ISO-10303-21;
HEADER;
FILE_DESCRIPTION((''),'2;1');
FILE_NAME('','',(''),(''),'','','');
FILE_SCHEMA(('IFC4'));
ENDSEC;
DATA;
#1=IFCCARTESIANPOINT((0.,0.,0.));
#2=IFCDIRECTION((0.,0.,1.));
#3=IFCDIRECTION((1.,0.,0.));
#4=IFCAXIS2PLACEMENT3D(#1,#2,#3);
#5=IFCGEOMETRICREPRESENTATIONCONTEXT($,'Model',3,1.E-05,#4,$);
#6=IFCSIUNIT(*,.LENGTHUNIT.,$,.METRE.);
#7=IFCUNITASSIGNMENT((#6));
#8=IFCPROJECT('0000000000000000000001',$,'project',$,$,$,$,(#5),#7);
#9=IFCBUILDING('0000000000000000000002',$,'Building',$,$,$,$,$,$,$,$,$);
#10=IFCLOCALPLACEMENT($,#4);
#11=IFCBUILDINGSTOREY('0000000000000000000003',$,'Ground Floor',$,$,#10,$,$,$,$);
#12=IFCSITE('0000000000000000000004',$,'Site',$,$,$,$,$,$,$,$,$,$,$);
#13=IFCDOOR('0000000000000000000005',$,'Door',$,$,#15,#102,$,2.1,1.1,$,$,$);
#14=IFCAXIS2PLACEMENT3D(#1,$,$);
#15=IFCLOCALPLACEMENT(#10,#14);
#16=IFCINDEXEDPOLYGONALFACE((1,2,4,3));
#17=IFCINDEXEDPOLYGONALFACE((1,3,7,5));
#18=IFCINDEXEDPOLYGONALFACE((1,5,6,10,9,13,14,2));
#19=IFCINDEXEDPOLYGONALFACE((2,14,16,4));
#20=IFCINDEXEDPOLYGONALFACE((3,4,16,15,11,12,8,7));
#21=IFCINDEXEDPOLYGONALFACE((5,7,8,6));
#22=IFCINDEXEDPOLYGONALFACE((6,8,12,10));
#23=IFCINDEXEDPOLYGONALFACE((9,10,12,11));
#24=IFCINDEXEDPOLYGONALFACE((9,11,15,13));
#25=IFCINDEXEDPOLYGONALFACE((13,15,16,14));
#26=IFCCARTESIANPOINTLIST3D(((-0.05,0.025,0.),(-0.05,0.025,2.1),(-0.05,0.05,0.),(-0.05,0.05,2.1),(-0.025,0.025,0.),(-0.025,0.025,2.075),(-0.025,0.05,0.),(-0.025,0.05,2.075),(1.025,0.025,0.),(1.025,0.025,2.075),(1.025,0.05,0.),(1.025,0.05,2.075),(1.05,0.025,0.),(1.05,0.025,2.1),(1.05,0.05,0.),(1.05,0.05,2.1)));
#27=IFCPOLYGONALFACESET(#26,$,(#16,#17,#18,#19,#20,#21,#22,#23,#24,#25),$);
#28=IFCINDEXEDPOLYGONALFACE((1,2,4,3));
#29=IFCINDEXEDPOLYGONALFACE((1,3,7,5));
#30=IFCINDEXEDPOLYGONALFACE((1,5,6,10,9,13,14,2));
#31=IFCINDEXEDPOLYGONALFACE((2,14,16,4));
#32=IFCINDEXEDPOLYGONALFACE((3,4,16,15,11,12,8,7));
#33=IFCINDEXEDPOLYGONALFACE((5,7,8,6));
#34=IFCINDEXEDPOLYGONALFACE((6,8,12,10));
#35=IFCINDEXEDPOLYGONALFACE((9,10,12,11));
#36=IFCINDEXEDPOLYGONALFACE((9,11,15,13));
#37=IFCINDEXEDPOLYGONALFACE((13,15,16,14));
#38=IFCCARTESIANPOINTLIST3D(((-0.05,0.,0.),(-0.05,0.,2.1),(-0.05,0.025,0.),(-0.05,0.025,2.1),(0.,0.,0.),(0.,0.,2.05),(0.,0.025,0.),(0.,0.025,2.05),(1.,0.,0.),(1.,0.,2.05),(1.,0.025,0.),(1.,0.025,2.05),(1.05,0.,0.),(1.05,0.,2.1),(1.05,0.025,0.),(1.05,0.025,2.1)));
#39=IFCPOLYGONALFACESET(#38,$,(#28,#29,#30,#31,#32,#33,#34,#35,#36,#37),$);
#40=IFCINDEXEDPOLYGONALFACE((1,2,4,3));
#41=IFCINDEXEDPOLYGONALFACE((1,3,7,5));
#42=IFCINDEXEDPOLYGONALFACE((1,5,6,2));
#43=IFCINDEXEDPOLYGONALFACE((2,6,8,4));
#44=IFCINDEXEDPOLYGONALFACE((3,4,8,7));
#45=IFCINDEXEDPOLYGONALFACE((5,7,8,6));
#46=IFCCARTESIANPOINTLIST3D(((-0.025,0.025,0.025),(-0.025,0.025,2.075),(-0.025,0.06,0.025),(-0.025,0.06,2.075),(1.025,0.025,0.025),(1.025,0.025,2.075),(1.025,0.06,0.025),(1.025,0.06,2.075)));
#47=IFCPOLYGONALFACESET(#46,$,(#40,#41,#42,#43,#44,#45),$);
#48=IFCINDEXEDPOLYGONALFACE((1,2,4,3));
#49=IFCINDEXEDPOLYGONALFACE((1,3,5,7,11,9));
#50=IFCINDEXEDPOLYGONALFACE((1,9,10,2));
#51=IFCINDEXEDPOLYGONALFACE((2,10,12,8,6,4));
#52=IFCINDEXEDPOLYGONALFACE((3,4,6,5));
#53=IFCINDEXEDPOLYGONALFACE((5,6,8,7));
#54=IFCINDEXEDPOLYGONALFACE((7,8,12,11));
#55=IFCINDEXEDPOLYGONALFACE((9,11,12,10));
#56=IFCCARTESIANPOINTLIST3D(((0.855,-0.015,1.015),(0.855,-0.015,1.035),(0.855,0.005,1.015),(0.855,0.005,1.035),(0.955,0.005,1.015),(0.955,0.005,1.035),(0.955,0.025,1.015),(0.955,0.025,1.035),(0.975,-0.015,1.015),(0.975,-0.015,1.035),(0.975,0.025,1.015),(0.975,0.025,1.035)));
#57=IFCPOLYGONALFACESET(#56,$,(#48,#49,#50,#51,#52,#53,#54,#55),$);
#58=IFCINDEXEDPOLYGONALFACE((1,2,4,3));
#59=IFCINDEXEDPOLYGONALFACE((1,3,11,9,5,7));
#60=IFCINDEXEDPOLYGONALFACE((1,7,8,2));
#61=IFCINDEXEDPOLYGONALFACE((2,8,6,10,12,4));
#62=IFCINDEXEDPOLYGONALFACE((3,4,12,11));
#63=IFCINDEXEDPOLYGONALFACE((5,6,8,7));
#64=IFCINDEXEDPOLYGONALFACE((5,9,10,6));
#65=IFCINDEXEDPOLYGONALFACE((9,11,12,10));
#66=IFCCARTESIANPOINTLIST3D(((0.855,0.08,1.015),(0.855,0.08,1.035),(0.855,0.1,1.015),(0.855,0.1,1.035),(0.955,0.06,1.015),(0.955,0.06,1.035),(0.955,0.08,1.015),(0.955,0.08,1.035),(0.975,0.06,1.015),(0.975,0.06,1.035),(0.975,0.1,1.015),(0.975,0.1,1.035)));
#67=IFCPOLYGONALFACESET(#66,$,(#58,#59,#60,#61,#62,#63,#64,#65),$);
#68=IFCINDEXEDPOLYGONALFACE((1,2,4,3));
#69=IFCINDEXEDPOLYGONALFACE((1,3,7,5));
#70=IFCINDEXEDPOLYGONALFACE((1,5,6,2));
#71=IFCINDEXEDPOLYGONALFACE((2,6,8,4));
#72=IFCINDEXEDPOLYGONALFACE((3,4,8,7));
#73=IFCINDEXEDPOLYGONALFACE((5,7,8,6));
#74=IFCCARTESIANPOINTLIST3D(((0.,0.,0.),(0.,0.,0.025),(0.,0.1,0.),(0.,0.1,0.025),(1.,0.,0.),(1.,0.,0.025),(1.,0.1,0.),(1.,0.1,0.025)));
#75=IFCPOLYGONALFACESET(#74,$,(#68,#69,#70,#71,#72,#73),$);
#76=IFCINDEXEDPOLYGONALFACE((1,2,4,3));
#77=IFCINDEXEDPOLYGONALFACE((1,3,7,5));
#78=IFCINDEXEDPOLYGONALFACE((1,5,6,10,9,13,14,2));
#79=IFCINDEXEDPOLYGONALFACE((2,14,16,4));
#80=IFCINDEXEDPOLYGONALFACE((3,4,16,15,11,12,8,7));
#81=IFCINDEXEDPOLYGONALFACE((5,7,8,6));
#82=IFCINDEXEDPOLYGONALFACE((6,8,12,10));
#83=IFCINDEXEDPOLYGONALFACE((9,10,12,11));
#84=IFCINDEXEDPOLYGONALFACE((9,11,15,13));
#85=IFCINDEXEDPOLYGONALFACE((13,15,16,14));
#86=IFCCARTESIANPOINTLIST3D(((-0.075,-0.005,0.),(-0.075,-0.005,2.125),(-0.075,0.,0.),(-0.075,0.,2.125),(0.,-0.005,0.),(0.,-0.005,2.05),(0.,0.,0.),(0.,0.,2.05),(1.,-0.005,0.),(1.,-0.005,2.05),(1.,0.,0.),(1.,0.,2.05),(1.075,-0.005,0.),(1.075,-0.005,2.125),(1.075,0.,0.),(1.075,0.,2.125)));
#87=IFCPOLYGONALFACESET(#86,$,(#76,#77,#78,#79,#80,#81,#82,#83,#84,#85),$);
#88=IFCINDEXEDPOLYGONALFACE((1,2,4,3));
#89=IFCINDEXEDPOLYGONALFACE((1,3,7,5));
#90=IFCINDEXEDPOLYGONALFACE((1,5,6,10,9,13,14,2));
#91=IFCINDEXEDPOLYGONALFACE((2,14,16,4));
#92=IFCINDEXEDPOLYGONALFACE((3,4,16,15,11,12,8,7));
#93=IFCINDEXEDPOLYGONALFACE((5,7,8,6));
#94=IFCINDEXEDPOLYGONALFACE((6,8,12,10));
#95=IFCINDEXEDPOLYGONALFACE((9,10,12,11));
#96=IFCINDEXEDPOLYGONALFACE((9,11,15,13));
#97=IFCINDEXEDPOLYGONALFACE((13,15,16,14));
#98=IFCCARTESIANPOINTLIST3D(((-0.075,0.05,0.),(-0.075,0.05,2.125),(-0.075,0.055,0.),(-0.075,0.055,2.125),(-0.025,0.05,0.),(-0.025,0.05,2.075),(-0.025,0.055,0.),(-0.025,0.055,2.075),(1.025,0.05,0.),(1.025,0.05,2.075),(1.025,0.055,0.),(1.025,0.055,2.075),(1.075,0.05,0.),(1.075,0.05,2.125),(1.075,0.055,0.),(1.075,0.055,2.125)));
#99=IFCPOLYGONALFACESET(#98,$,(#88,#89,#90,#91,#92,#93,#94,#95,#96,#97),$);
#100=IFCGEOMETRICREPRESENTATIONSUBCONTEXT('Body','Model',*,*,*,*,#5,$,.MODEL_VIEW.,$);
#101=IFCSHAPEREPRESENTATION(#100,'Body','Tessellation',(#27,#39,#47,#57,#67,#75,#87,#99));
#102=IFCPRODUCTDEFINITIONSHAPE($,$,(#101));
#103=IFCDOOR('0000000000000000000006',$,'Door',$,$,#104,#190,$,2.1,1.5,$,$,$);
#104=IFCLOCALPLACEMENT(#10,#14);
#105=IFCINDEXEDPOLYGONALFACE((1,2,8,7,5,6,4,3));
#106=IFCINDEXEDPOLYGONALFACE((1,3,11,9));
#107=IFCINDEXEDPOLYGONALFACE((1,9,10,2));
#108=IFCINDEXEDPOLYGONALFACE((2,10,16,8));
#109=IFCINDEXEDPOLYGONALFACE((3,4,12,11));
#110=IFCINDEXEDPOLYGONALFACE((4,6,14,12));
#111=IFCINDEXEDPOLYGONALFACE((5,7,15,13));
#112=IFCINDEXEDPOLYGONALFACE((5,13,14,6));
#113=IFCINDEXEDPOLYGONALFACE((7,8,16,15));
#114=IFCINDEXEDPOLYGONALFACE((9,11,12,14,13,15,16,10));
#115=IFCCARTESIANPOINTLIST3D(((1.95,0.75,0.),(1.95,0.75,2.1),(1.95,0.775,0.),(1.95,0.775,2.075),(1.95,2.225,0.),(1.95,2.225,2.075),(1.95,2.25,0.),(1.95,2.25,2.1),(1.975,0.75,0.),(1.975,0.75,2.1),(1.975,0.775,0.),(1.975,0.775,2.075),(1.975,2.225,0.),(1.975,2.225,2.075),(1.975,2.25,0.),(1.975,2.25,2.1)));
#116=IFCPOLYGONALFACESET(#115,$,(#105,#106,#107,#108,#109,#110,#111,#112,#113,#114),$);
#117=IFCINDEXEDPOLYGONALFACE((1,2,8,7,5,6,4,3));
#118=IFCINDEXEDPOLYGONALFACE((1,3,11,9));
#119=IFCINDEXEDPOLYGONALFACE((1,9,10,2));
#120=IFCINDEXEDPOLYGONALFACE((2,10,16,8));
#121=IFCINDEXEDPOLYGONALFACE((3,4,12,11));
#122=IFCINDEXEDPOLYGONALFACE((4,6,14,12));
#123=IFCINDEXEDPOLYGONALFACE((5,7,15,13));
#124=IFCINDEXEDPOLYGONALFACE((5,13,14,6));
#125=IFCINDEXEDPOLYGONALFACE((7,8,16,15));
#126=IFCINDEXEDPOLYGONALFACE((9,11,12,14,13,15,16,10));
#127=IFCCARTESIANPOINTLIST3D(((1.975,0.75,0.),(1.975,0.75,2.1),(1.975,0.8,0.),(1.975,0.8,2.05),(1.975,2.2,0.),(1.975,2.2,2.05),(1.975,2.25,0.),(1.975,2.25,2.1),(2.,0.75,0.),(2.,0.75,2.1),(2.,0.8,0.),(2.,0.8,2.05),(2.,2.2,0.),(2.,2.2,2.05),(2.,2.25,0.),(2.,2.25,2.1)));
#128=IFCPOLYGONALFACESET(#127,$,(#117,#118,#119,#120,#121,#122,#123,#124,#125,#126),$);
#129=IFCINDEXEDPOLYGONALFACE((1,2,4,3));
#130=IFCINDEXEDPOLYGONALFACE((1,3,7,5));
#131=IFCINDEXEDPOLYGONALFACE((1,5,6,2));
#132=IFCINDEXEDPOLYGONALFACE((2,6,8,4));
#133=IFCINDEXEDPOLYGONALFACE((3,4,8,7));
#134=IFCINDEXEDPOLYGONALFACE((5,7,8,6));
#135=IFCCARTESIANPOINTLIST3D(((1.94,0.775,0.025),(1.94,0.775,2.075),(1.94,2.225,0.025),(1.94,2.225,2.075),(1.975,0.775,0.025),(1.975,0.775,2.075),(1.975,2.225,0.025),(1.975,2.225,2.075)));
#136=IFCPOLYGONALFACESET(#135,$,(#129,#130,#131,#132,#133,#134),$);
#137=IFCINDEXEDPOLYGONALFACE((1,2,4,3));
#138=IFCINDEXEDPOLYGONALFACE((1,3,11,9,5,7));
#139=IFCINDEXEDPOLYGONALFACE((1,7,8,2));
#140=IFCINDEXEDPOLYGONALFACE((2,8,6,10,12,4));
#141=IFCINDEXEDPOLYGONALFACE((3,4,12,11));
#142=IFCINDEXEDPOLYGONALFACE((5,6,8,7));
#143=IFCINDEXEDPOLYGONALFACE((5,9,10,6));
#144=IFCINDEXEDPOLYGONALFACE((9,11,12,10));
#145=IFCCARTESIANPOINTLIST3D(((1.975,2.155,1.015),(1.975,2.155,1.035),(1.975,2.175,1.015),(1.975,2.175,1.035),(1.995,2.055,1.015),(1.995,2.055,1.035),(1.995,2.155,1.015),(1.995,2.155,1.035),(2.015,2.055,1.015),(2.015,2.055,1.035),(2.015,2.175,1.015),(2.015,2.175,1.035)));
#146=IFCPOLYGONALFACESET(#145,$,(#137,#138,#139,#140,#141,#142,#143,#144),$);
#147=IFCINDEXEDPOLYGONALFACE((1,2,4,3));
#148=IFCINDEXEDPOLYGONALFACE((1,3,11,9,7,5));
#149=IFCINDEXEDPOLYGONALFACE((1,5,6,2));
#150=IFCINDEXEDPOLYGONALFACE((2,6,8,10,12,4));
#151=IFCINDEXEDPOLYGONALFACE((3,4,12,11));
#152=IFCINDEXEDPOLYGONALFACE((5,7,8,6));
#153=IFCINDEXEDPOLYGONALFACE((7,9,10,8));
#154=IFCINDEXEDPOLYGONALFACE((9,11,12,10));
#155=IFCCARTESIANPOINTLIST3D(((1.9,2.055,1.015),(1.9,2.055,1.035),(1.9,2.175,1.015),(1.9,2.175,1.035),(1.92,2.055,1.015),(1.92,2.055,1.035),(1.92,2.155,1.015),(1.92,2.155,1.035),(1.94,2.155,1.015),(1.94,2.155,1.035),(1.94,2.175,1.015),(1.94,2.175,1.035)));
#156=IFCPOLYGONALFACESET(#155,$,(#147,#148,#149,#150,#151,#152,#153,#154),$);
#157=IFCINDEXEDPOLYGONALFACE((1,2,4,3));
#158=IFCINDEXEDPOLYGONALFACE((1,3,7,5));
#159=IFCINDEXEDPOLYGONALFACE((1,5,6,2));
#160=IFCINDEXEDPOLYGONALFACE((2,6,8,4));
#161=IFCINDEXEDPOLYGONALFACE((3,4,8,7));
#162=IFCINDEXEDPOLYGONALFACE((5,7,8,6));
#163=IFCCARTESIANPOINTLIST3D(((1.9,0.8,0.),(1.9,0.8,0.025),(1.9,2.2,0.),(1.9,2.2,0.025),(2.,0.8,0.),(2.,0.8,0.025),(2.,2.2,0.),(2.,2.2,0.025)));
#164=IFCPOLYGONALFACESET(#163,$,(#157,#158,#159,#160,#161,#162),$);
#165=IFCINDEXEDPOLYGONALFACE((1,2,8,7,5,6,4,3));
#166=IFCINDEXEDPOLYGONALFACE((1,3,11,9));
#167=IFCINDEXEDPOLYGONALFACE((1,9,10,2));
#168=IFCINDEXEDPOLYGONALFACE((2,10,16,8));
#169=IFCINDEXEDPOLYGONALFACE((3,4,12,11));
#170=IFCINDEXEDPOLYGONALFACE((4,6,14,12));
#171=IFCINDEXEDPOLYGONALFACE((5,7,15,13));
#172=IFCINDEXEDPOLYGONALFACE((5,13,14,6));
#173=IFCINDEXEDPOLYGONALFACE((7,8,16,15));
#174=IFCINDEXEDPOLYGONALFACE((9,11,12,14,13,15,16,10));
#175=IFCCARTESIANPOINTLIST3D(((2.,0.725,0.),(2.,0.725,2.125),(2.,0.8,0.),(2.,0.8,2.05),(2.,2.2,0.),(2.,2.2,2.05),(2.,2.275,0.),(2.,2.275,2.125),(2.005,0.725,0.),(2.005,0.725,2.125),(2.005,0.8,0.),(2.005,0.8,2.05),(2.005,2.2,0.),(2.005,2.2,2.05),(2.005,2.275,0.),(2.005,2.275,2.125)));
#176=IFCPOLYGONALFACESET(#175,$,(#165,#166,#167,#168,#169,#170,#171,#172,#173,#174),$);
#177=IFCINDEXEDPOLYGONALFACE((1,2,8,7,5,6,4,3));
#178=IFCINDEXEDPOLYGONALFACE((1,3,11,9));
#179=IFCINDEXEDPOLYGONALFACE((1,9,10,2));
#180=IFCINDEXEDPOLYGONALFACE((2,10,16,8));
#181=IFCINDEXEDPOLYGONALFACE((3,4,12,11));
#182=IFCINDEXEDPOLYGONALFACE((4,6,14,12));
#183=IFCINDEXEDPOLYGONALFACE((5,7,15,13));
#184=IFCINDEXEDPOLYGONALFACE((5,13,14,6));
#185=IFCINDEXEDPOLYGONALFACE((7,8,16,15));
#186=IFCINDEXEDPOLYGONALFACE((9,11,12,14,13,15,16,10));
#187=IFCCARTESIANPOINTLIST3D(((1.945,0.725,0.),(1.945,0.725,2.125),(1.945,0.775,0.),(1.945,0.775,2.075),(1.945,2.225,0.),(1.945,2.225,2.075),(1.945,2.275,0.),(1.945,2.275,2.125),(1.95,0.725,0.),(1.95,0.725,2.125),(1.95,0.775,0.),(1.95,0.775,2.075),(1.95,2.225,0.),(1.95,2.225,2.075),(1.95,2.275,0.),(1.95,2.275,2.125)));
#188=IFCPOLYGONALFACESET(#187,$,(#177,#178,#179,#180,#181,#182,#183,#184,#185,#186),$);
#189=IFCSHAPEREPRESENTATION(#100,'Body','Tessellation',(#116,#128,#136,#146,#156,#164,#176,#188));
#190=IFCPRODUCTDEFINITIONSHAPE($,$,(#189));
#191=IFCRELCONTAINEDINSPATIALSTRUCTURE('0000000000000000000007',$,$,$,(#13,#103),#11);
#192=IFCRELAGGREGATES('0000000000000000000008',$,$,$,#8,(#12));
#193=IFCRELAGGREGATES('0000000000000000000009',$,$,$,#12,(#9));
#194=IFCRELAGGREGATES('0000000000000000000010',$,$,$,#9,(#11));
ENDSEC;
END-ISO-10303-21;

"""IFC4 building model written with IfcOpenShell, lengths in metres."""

from ifc_helpers import new_model, si_unit, frame, origin_with_axes, place, context, subcontext, project, spatial, line, indexed_curve, outline, extrude, element, save


model = new_model("IFC4")

# Units and contexts
model_context = context("Model", 3, precision=1e-05, world=origin_with_axes())
body_context = subcontext(model_context, "Body", "Model", "MODEL_VIEW")
ifc_project = project(units=[si_unit("LENGTHUNIT", "METRE")], contexts=[model_context])

# Site, building, storey
site = spatial("IfcSite", under=ifc_project, Name="Site")
building = spatial("IfcBuilding", under=site, Name="Building")
storey_placement = place(None, origin_with_axes())
storey = spatial("IfcBuildingStorey", under=building, at=storey_placement, Name="Ground Floor")

# Doors
door_1_placement = place(storey_placement, frame((-0.05, 0.0, 0.0), z_axis=(0.0, 0.0, 1.0), x_axis=(1.0, 0.0, 0.0)))
element("IfcDoor", 1, at=door_1_placement, inside=storey, Name="Door", OverallHeight=2.1, OverallWidth=1.1, context=body_context, shape_type="SweptSolid", body=[
    extrude(outline(indexed_curve([(0.0, 0.0), (0.0, 2.1), (1.1, 2.1), (1.1, 0.0), (1.075, 0.0), (1.075, 2.075), (0.025, 2.075), (0.025, 0.0)], segments=[line(1, 2, 3, 4, 5, 6, 7, 8, 1)])), frame((0.0, 0.025, 0.0), z_axis=(0.0, -1.0, 0.0), x_axis=(1.0, 0.0, 0.0)), (0.0, 0.0, -1.0), 0.025),
    extrude(outline(indexed_curve([(0.0, 0.0), (0.0, 2.1), (1.1, 2.1), (1.1, 0.0), (1.05, 0.0), (1.05, 2.05), (0.05, 2.05), (0.05, 0.0)], segments=[line(1, 2, 3, 4, 5, 6, 7, 8, 1)])), frame((0.0, 0.0, 0.0), z_axis=(0.0, -1.0, 0.0), x_axis=(1.0, 0.0, 0.0)), (0.0, 0.0, -1.0), 0.025),
    extrude(outline(indexed_curve([(0.0, 0.0), (1.05, 0.0), (1.05, 0.035), (0.0, 0.035)], segments=[line(1, 2, 3, 4, 1)])), frame((0.025, 0.025, 0.025), z_axis=(0.0, 0.0, 1.0), x_axis=(1.0, 0.0, 0.0)), (0.0, 0.0, 1.0), 2.05),
    extrude(outline(indexed_curve([(0.0, 0.0), (0.0, -0.04), (-0.12, -0.04), (-0.12, -0.02), (-0.02, -0.02), (-0.02, 0.0)], segments=[line(1, 2, 3, 4, 5, 6, 1)])), frame((1.025, 0.025, 1.015), z_axis=(0.0, 0.0, 1.0), x_axis=(1.0, 0.0, 0.0)), (0.0, 0.0, 1.0), 0.02),
    extrude(outline(indexed_curve([(0.0, 0.0), (0.0, 0.04), (-0.12, 0.04), (-0.12, 0.02), (-0.02, 0.02), (-0.02, 0.0)], segments=[line(1, 2, 3, 4, 5, 6, 1)])), frame((1.025, 0.06, 1.015), z_axis=(0.0, 0.0, 1.0), x_axis=(1.0, 0.0, 0.0)), (0.0, 0.0, 1.0), 0.02),
    extrude(outline(indexed_curve([(0.0, 0.0), (1.0, 0.0), (1.0, 0.1), (0.0, 0.1)], segments=[line(1, 2, 3, 4, 1)])), frame((0.05, 0.0, 0.0), z_axis=(0.0, 0.0, 1.0), x_axis=(1.0, 0.0, 0.0)), (0.0, 0.0, 1.0), 0.025),
    extrude(outline(indexed_curve([(0.0, 0.0), (0.0, 2.125), (1.15, 2.125), (1.15, 0.0), (1.075, 0.0), (1.075, 2.05), (0.075, 2.05), (0.075, 0.0)], segments=[line(1, 2, 3, 4, 5, 6, 7, 8, 1)])), frame((-0.025, -0.005, 0.0), z_axis=(0.0, -1.0, 0.0), x_axis=(1.0, 0.0, 0.0)), (0.0, 0.0, -1.0), 0.005),
    extrude(outline(indexed_curve([(0.0, 0.0), (0.0, 2.125), (1.15, 2.125), (1.15, 0.0), (1.1, 0.0), (1.1, 2.075), (0.05, 2.075), (0.05, 0.0)], segments=[line(1, 2, 3, 4, 5, 6, 7, 8, 1)])), frame((-0.025, 0.05, 0.0), z_axis=(0.0, -1.0, 0.0), x_axis=(1.0, 0.0, 0.0)), (0.0, 0.0, -1.0), 0.005),
])
door_2_placement = place(storey_placement, frame((2.0, 0.75, 0.0), z_axis=(0.0, 0.0, 1.0), x_axis=(0.0, 1.0, 0.0)))
element("IfcDoor", 2, at=door_2_placement, inside=storey, Name="Door", OverallHeight=2.1, OverallWidth=1.5, context=body_context, shape_type="SweptSolid", body=[
    extrude(outline(indexed_curve([(0.0, 0.0), (0.0, 2.1), (1.5, 2.1), (1.5, 0.0), (1.475, 0.0), (1.475, 2.075), (0.025, 2.075), (0.025, 0.0)], segments=[line(1, 2, 3, 4, 5, 6, 7, 8, 1)])), frame((0.0, 0.025, 0.0), z_axis=(0.0, -1.0, 0.0), x_axis=(1.0, 0.0, 0.0)), (0.0, 0.0, -1.0), 0.025),
    extrude(outline(indexed_curve([(0.0, 0.0), (0.0, 2.1), (1.5, 2.1), (1.5, 0.0), (1.45, 0.0), (1.45, 2.05), (0.05, 2.05), (0.05, 0.0)], segments=[line(1, 2, 3, 4, 5, 6, 7, 8, 1)])), frame((0.0, 0.0, 0.0), z_axis=(0.0, -1.0, 0.0), x_axis=(1.0, 0.0, 0.0)), (0.0, 0.0, -1.0), 0.025),
    extrude(outline(indexed_curve([(0.0, 0.0), (1.45, 0.0), (1.45, 0.035), (0.0, 0.035)], segments=[line(1, 2, 3, 4, 1)])), frame((0.025, 0.025, 0.025), z_axis=(0.0, 0.0, 1.0), x_axis=(1.0, 0.0, 0.0)), (0.0, 0.0, 1.0), 2.05),
    extrude(outline(indexed_curve([(0.0, 0.0), (0.0, -0.04), (-0.12, -0.04), (-0.12, -0.02), (-0.02, -0.02), (-0.02, 0.0)], segments=[line(1, 2, 3, 4, 5, 6, 1)])), frame((1.425, 0.025, 1.015), z_axis=(0.0, 0.0, 1.0), x_axis=(1.0, 0.0, 0.0)), (0.0, 0.0, 1.0), 0.02),
    extrude(outline(indexed_curve([(0.0, 0.0), (0.0, 0.04), (-0.12, 0.04), (-0.12, 0.02), (-0.02, 0.02), (-0.02, 0.0)], segments=[line(1, 2, 3, 4, 5, 6, 1)])), frame((1.425, 0.06, 1.015), z_axis=(0.0, 0.0, 1.0), x_axis=(1.0, 0.0, 0.0)), (0.0, 0.0, 1.0), 0.02),
    extrude(outline(indexed_curve([(0.0, 0.0), (1.4, 0.0), (1.4, 0.1), (0.0, 0.1)], segments=[line(1, 2, 3, 4, 1)])), frame((0.05, 0.0, 0.0), z_axis=(0.0, 0.0, 1.0), x_axis=(1.0, 0.0, 0.0)), (0.0, 0.0, 1.0), 0.025),
    extrude(outline(indexed_curve([(0.0, 0.0), (0.0, 2.125), (1.55, 2.125), (1.55, 0.0), (1.475, 0.0), (1.475, 2.05), (0.075, 2.05), (0.075, 0.0)], segments=[line(1, 2, 3, 4, 5, 6, 7, 8, 1)])), frame((-0.025, -0.005, 0.0), z_axis=(0.0, -1.0, 0.0), x_axis=(1.0, 0.0, 0.0)), (0.0, 0.0, -1.0), 0.005),
    extrude(outline(indexed_curve([(0.0, 0.0), (0.0, 2.125), (1.55, 2.125), (1.55, 0.0), (1.5, 0.0), (1.5, 2.075), (0.05, 2.075), (0.05, 0.0)], segments=[line(1, 2, 3, 4, 5, 6, 7, 8, 1)])), frame((-0.025, 0.05, 0.0), z_axis=(0.0, -1.0, 0.0), x_axis=(1.0, 0.0, 0.0)), (0.0, 0.0, -1.0), 0.005),
])

save(model, "model.ifc")
